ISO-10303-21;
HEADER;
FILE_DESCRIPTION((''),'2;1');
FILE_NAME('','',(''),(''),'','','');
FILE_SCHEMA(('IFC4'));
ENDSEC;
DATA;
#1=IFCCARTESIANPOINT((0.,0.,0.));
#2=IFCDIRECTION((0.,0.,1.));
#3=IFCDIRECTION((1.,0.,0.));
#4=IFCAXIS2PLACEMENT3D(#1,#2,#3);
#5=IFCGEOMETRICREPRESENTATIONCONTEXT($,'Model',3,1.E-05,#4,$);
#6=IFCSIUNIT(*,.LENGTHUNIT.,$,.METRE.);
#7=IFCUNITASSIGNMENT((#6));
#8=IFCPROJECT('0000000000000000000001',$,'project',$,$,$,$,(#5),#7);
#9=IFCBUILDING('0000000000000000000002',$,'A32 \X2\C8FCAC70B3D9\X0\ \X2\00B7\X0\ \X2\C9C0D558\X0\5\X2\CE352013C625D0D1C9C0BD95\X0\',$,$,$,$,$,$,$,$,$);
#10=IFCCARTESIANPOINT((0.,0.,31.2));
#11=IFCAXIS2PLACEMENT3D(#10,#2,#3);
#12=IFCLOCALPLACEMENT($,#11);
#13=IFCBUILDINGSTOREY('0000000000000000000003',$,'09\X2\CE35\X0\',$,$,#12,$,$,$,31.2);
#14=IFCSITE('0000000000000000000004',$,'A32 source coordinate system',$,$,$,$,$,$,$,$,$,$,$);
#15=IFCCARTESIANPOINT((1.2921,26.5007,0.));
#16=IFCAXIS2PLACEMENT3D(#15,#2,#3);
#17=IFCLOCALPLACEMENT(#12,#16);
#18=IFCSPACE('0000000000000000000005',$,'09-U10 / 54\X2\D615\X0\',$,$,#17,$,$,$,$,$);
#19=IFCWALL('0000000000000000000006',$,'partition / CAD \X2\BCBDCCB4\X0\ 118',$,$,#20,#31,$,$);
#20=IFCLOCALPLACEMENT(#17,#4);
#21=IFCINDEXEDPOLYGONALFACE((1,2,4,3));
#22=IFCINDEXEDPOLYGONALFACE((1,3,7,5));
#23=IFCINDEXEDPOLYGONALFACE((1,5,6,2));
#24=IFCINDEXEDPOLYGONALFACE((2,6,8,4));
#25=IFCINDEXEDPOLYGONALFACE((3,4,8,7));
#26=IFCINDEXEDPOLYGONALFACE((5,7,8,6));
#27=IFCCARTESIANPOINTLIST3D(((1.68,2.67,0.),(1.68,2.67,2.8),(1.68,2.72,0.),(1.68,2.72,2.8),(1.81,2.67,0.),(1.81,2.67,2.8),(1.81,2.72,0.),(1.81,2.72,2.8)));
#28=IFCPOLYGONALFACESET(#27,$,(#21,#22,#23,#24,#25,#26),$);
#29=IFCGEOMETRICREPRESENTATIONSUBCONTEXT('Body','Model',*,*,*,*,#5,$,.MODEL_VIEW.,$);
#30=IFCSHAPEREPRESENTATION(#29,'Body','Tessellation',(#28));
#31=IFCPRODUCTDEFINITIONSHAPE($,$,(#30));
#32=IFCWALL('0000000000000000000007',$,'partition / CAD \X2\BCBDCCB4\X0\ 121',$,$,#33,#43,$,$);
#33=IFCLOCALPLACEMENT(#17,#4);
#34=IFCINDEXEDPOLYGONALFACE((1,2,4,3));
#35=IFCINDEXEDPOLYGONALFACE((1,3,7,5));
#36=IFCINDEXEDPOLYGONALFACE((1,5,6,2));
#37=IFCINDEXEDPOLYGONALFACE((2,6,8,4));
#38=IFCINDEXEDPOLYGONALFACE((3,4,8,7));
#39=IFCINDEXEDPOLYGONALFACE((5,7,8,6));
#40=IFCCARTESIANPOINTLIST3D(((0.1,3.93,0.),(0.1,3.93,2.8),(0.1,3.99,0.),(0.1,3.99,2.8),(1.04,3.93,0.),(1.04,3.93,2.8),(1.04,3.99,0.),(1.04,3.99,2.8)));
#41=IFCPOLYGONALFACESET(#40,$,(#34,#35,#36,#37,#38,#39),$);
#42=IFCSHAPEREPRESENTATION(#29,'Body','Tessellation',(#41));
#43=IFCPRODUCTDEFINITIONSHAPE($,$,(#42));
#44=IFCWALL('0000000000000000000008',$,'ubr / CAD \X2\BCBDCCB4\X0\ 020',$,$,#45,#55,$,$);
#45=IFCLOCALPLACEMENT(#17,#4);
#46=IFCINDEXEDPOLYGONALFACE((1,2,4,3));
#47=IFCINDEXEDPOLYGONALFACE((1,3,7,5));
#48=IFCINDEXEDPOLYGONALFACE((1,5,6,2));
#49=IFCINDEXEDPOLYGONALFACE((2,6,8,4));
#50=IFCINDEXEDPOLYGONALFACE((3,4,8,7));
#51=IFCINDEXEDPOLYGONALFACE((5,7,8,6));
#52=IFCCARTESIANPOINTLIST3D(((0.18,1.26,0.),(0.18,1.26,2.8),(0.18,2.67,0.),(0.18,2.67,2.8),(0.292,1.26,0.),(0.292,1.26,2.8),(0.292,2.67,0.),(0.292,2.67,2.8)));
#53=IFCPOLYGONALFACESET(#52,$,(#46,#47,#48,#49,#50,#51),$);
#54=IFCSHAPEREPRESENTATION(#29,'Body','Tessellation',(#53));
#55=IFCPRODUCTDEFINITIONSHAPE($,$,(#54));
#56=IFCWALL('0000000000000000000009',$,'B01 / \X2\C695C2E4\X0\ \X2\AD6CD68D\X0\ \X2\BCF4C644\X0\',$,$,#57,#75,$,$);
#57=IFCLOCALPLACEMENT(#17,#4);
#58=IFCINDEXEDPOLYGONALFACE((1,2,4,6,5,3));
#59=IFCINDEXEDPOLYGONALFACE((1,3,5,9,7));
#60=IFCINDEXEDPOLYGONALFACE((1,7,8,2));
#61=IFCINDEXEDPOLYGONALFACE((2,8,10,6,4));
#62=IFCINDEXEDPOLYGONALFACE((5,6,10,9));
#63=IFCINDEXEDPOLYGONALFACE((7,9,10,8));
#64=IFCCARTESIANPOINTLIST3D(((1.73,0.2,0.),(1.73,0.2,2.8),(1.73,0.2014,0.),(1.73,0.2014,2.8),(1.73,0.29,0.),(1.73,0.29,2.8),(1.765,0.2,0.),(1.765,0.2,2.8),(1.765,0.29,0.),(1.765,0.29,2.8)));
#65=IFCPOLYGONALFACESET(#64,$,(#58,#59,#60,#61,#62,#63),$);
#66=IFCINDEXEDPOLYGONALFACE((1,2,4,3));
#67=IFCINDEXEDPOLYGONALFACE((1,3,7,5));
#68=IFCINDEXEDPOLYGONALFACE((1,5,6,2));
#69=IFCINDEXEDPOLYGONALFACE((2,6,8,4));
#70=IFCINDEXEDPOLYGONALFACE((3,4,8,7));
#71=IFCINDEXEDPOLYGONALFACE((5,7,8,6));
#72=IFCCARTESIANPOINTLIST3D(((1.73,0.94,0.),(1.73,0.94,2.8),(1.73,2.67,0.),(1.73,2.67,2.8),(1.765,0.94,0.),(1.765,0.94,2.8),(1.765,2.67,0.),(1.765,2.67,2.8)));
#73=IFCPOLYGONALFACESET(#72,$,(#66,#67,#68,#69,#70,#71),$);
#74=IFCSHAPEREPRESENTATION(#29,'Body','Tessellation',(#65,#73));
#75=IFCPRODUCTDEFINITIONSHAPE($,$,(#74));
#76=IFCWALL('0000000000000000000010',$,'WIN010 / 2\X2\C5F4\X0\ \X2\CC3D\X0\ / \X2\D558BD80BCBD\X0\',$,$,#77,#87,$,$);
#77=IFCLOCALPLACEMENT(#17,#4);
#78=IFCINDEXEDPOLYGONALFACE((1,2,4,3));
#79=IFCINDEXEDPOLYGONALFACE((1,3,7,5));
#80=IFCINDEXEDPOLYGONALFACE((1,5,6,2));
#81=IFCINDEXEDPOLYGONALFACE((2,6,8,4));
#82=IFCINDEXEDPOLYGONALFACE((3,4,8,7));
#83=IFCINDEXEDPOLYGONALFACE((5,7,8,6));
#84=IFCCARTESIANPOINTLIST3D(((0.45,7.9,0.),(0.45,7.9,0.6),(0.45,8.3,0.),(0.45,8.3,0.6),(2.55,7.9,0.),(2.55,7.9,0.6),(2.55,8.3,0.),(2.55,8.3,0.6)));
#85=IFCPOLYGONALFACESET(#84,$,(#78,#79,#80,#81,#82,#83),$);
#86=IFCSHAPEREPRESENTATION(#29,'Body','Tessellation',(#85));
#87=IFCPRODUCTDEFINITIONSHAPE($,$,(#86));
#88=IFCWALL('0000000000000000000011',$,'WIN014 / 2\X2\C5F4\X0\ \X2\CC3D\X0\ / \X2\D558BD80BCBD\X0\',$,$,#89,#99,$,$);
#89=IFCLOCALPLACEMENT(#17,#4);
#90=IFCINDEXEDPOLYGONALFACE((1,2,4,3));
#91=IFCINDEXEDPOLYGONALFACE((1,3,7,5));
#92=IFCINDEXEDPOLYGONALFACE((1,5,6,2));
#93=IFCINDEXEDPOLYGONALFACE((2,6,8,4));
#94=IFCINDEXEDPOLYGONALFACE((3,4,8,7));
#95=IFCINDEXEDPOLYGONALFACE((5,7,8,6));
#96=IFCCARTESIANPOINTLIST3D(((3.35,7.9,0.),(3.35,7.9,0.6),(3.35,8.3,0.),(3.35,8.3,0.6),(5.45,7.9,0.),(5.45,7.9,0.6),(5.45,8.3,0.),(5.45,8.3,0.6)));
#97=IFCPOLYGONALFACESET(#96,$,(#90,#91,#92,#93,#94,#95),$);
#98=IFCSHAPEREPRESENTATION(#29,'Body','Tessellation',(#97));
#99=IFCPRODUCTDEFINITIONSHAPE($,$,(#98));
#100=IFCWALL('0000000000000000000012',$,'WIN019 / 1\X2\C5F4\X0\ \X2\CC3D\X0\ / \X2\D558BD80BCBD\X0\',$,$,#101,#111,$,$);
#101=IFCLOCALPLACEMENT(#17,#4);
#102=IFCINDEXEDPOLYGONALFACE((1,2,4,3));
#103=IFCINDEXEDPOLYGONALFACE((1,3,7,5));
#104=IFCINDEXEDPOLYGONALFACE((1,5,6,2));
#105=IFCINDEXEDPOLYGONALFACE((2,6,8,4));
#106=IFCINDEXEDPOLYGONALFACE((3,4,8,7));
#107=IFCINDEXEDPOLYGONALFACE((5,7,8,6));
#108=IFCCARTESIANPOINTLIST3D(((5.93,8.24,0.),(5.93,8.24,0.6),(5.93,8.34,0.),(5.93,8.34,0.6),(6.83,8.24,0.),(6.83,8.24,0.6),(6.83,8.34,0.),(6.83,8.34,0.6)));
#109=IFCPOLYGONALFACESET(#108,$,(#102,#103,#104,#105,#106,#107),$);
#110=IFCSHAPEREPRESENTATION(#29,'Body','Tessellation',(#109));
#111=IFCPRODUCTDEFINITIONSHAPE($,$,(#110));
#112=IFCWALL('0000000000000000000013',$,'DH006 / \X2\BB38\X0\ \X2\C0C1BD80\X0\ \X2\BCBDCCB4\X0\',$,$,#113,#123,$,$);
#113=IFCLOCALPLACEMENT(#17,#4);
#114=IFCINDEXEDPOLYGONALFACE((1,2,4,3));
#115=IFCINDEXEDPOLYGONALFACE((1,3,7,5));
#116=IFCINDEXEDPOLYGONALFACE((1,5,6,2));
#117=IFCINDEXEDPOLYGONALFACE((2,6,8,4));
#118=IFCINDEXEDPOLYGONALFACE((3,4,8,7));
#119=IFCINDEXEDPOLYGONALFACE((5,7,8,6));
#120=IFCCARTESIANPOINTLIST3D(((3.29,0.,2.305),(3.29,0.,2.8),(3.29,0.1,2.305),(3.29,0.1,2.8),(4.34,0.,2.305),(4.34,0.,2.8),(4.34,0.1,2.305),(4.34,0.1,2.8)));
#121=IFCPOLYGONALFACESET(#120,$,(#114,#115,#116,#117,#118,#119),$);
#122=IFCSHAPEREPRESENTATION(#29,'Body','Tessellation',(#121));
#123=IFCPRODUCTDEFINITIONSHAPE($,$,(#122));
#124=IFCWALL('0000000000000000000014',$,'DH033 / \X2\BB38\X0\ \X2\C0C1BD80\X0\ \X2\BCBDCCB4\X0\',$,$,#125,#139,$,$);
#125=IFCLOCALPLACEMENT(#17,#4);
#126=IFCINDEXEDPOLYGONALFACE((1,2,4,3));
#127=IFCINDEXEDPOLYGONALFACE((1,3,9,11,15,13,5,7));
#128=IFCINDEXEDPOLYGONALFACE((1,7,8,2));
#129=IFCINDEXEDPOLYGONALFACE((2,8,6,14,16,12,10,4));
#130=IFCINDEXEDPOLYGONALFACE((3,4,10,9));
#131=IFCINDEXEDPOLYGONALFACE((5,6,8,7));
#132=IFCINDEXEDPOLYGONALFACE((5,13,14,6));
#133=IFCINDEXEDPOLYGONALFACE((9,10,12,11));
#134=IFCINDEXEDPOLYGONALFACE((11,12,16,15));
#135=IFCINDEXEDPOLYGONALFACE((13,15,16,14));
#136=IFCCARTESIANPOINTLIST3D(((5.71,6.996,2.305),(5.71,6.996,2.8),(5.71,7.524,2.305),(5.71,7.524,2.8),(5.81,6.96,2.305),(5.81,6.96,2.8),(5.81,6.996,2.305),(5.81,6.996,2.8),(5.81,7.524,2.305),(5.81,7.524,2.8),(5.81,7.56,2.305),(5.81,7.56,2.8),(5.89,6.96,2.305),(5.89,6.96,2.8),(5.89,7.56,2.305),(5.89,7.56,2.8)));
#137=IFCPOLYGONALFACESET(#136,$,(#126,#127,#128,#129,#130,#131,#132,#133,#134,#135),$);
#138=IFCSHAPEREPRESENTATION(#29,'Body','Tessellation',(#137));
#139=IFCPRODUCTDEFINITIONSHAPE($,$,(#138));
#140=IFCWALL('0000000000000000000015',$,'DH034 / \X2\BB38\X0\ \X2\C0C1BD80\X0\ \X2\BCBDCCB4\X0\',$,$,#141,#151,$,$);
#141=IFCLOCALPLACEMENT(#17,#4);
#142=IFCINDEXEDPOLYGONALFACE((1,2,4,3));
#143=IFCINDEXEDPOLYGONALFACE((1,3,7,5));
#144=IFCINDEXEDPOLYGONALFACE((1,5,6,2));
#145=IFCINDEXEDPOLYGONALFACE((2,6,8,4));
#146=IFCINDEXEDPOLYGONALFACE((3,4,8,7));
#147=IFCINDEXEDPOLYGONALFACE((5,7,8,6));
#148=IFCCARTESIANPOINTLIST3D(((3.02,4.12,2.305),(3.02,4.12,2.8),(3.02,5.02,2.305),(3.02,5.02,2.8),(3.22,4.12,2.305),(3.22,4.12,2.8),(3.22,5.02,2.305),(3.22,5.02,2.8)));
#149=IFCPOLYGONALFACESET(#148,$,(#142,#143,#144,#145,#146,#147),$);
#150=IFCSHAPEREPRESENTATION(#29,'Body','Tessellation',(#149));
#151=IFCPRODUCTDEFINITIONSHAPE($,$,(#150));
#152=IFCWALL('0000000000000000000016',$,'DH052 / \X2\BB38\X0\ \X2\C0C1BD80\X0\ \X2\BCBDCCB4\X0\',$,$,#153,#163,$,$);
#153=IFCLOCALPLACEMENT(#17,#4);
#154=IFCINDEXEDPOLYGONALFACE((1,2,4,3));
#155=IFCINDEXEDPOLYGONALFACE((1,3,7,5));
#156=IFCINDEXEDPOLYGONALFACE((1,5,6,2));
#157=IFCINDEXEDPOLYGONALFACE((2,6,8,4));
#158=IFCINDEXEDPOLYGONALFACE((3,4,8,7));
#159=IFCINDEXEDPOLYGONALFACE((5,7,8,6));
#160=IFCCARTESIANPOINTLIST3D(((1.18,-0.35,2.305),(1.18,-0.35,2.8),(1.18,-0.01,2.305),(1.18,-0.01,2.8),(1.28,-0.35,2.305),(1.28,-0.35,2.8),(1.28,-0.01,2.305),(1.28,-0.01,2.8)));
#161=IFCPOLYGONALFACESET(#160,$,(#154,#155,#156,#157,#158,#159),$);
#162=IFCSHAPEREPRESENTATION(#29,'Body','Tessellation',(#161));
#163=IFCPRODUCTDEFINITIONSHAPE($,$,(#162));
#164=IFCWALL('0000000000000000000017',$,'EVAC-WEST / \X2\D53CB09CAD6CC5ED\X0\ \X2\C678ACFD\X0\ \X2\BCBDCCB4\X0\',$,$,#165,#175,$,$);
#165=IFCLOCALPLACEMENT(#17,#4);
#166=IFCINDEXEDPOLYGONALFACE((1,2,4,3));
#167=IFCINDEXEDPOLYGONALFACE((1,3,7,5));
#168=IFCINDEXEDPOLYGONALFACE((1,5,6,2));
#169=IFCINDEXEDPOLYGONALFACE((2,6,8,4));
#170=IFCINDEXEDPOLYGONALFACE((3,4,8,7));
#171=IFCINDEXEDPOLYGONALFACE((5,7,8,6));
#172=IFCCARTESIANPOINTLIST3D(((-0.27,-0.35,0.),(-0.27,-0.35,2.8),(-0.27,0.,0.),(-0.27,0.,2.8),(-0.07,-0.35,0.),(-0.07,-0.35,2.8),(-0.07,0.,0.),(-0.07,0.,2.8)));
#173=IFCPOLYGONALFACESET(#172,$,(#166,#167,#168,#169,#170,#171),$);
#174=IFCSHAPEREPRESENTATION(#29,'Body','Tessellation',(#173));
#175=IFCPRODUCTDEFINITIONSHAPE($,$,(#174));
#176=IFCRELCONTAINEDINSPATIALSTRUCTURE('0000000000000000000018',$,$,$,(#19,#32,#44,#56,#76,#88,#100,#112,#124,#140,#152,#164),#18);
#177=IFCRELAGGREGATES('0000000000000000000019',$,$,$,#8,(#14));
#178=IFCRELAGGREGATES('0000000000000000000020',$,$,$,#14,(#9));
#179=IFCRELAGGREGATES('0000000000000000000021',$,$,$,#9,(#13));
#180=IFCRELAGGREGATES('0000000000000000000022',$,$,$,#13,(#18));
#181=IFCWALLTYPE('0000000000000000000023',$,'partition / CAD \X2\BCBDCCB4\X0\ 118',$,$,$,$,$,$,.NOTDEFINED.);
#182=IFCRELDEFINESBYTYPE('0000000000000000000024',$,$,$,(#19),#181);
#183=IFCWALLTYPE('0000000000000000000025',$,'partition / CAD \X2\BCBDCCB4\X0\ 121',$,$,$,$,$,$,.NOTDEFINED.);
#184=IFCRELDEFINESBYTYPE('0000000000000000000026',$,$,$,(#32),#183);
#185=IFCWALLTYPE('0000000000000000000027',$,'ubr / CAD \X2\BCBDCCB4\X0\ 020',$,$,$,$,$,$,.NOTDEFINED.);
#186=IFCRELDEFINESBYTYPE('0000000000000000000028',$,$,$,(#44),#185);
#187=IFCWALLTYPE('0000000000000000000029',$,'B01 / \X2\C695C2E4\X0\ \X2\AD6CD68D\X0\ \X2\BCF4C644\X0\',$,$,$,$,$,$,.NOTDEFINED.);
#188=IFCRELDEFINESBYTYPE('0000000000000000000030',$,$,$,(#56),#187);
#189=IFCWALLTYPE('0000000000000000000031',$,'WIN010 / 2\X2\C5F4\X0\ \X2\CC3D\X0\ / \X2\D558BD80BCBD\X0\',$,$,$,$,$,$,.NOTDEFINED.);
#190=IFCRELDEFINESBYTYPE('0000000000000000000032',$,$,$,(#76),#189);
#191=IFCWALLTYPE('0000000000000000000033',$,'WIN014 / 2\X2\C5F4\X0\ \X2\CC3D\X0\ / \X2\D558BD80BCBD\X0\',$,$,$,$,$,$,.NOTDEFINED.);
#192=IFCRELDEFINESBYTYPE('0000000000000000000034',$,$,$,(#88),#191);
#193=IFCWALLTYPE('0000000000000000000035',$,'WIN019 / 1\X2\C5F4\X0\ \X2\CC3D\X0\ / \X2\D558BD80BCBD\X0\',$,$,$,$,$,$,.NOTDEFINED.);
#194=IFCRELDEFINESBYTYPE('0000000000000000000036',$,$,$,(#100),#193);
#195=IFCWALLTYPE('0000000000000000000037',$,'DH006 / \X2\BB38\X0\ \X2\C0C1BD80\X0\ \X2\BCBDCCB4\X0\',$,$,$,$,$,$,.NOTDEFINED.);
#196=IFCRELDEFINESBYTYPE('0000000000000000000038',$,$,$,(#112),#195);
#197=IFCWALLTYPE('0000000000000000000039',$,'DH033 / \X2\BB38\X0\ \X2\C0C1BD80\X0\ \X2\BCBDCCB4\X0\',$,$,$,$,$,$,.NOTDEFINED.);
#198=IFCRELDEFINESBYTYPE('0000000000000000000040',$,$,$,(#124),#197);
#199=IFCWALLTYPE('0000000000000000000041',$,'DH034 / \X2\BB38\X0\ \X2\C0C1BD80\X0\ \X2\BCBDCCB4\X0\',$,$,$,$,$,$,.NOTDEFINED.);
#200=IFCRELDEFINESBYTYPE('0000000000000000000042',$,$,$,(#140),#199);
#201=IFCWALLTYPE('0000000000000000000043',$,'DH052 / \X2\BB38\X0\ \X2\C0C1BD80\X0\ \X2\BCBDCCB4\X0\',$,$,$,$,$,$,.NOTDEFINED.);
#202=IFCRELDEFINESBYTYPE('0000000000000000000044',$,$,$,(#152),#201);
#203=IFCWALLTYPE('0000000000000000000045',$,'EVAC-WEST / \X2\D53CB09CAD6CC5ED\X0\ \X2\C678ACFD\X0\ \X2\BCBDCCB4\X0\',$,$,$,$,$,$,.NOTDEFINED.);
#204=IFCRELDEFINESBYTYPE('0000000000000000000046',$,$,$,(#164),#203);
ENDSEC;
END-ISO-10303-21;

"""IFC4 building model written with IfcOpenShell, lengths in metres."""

from ifc_helpers import new_model, si_unit, frame, origin, origin_with_axes, place, context, subcontext, project, spatial, polyline, outline, extrude, source, transform, mapped, type_object, type_shapes, element, save


model = new_model("IFC4")

# Units and contexts
model_context = context("Model", 3, precision=1e-05, world=origin_with_axes())
body_context = subcontext(model_context, "Body", "Model", "MODEL_VIEW")
ifc_project = project(units=[si_unit("LENGTHUNIT", "METRE")], contexts=[model_context])

# Site, building, storey, space
site = spatial("IfcSite", under=ifc_project, Name="A32 source coordinate system")
building = spatial("IfcBuilding", under=site, Name="A32 주거동 · 지하5층–옥탑지붕")
storey_placement = place(None, frame((0.0, 0.0, 31.2), z_axis=(0.0, 0.0, 1.0), x_axis=(1.0, 0.0, 0.0)))
storey = spatial("IfcBuildingStorey", under=building, at=storey_placement, Name="09층", Elevation=31.2)
space_placement = place(storey_placement, frame((1.2921, 26.5007, 0.0), z_axis=(0.0, 0.0, 1.0), x_axis=(1.0, 0.0, 0.0)))
space = spatial("IfcSpace", under=storey, at=space_placement, Name="09-U10 / 54형")

# Walls
wall_type_1 = type_object("IfcWallType", Name="partition / CAD 벽체 118", PredefinedType="NOTDEFINED")
shared_shape_1 = source(origin(), body_context, "Body", "SweptSolid", [
    extrude(outline(polyline([(1.81, 2.67), (1.68, 2.67), (1.68, 2.72), (1.81, 2.72), (1.81, 2.67)])), origin(), (0.0, 0.0, 1.0), 2.8),
])
type_shapes(wall_type_1, [shared_shape_1])
wall_1_placement = place(space_placement, origin_with_axes())
element("IfcWall", 1, at=wall_1_placement, inside=space, type_object=wall_type_1, Name="partition / CAD 벽체 118", context=body_context, shape_type="MappedRepresentation", body=[
    mapped(shared_shape_1, transform((0.0, 0.0, 0.0), scale=1.0)),
])
wall_type_2 = type_object("IfcWallType", Name="partition / CAD 벽체 121", PredefinedType="NOTDEFINED")
shared_shape_2 = source(origin(), body_context, "Body", "SweptSolid", [
    extrude(outline(polyline([(0.1, 3.99), (1.04, 3.99), (1.04, 3.93), (0.1, 3.93), (0.1, 3.99)])), origin(), (0.0, 0.0, 1.0), 2.8),
])
type_shapes(wall_type_2, [shared_shape_2])
wall_2_placement = place(space_placement, origin_with_axes())
element("IfcWall", 2, at=wall_2_placement, inside=space, type_object=wall_type_2, Name="partition / CAD 벽체 121", context=body_context, shape_type="MappedRepresentation", body=[
    mapped(shared_shape_2, transform((0.0, 0.0, 0.0), scale=1.0)),
])
wall_type_3 = type_object("IfcWallType", Name="ubr / CAD 벽체 020", PredefinedType="NOTDEFINED")
shared_shape_3 = source(origin(), body_context, "Body", "SweptSolid", [
    extrude(outline(polyline([(0.18, 1.26), (0.18, 2.67), (0.292, 2.67), (0.292, 1.26), (0.18, 1.26)])), origin(), (0.0, 0.0, 1.0), 2.8),
])
type_shapes(wall_type_3, [shared_shape_3])
wall_3_placement = place(space_placement, origin_with_axes())
element("IfcWall", 3, at=wall_3_placement, inside=space, type_object=wall_type_3, Name="ubr / CAD 벽체 020", context=body_context, shape_type="MappedRepresentation", body=[
    mapped(shared_shape_3, transform((0.0, 0.0, 0.0), scale=1.0)),
])
wall_type_4 = type_object("IfcWallType", Name="B01 / 욕실 구획 보완", PredefinedType="NOTDEFINED")
shared_shape_4 = source(origin(), body_context, "Body", "SweptSolid", [
    extrude(outline(polyline([(1.765, 0.2), (1.73, 0.2), (1.73, 0.2014), (1.73, 0.29), (1.765, 0.29), (1.765, 0.2)])), origin(), (0.0, 0.0, 1.0), 2.8),
    extrude(outline(polyline([(1.765, 2.67), (1.765, 0.94), (1.73, 0.94), (1.73, 2.67), (1.765, 2.67)])), origin(), (0.0, 0.0, 1.0), 2.8),
])
type_shapes(wall_type_4, [shared_shape_4])
wall_4_placement = place(space_placement, origin_with_axes())
element("IfcWall", 4, at=wall_4_placement, inside=space, type_object=wall_type_4, Name="B01 / 욕실 구획 보완", context=body_context, shape_type="MappedRepresentation", body=[
    mapped(shared_shape_4, transform((0.0, 0.0, 0.0), scale=1.0)),
])
wall_type_5 = type_object("IfcWallType", Name="WIN010 / 2열 창 / 하부벽", PredefinedType="NOTDEFINED")
shared_shape_5 = source(origin(), body_context, "Body", "SweptSolid", [
    extrude(outline(polyline([(2.55, 8.3), (2.55, 7.9), (0.45, 7.9), (0.45, 8.3), (2.55, 8.3)])), origin(), (0.0, 0.0, 1.0), 0.6),
])
type_shapes(wall_type_5, [shared_shape_5])
wall_5_placement = place(space_placement, origin_with_axes())
element("IfcWall", 5, at=wall_5_placement, inside=space, type_object=wall_type_5, Name="WIN010 / 2열 창 / 하부벽", context=body_context, shape_type="MappedRepresentation", body=[
    mapped(shared_shape_5, transform((0.0, 0.0, 0.0), scale=1.0)),
])
wall_type_6 = type_object("IfcWallType", Name="WIN014 / 2열 창 / 하부벽", PredefinedType="NOTDEFINED")
shared_shape_6 = source(origin(), body_context, "Body", "SweptSolid", [
    extrude(outline(polyline([(5.45, 8.3), (5.45, 7.9), (3.35, 7.9), (3.35, 8.3), (5.45, 8.3)])), origin(), (0.0, 0.0, 1.0), 0.6),
])
type_shapes(wall_type_6, [shared_shape_6])
wall_6_placement = place(space_placement, origin_with_axes())
element("IfcWall", 6, at=wall_6_placement, inside=space, type_object=wall_type_6, Name="WIN014 / 2열 창 / 하부벽", context=body_context, shape_type="MappedRepresentation", body=[
    mapped(shared_shape_6, transform((0.0, 0.0, 0.0), scale=1.0)),
])
wall_type_7 = type_object("IfcWallType", Name="WIN019 / 1열 창 / 하부벽", PredefinedType="NOTDEFINED")
shared_shape_7 = source(origin(), body_context, "Body", "SweptSolid", [
    extrude(outline(polyline([(6.83, 8.34), (6.83, 8.24), (5.93, 8.24), (5.93, 8.34), (6.83, 8.34)])), origin(), (0.0, 0.0, 1.0), 0.6),
])
type_shapes(wall_type_7, [shared_shape_7])
wall_7_placement = place(space_placement, origin_with_axes())
element("IfcWall", 7, at=wall_7_placement, inside=space, type_object=wall_type_7, Name="WIN019 / 1열 창 / 하부벽", context=body_context, shape_type="MappedRepresentation", body=[
    mapped(shared_shape_7, transform((0.0, 0.0, 0.0), scale=1.0)),
])
wall_type_8 = type_object("IfcWallType", Name="DH006 / 문 상부 벽체", PredefinedType="NOTDEFINED")
shared_shape_8 = source(origin(), body_context, "Body", "SweptSolid", [
    extrude(outline(polyline([(4.34, 0.0), (3.29, 0.0), (3.29, 0.1), (4.34, 0.1), (4.34, 0.0)])), frame((0.0, 0.0, 2.305)), (0.0, 0.0, 1.0), 0.495),
])
type_shapes(wall_type_8, [shared_shape_8])
wall_8_placement = place(space_placement, origin_with_axes())
element("IfcWall", 8, at=wall_8_placement, inside=space, type_object=wall_type_8, Name="DH006 / 문 상부 벽체", context=body_context, shape_type="MappedRepresentation", body=[
    mapped(shared_shape_8, transform((0.0, 0.0, 0.0), scale=1.0)),
])
wall_type_9 = type_object("IfcWallType", Name="DH033 / 문 상부 벽체", PredefinedType="NOTDEFINED")
shared_shape_9 = source(origin(), body_context, "Body", "SweptSolid", [
    extrude(outline(polyline([(5.81, 6.996), (5.71, 6.996), (5.71, 7.524), (5.81, 7.524), (5.81, 7.56), (5.89, 7.56), (5.89, 6.96), (5.81, 6.96), (5.81, 6.996)])), frame((0.0, 0.0, 2.305)), (0.0, 0.0, 1.0), 0.495),
])
type_shapes(wall_type_9, [shared_shape_9])
wall_9_placement = place(space_placement, origin_with_axes())
element("IfcWall", 9, at=wall_9_placement, inside=space, type_object=wall_type_9, Name="DH033 / 문 상부 벽체", context=body_context, shape_type="MappedRepresentation", body=[
    mapped(shared_shape_9, transform((0.0, 0.0, 0.0), scale=1.0)),
])
wall_type_10 = type_object("IfcWallType", Name="DH034 / 문 상부 벽체", PredefinedType="NOTDEFINED")
shared_shape_10 = source(origin(), body_context, "Body", "SweptSolid", [
    extrude(outline(polyline([(3.22, 4.12), (3.02, 4.12), (3.02, 5.02), (3.22, 5.02), (3.22, 4.12)])), frame((0.0, 0.0, 2.305)), (0.0, 0.0, 1.0), 0.495),
])
type_shapes(wall_type_10, [shared_shape_10])
wall_10_placement = place(space_placement, origin_with_axes())
element("IfcWall", 10, at=wall_10_placement, inside=space, type_object=wall_type_10, Name="DH034 / 문 상부 벽체", context=body_context, shape_type="MappedRepresentation", body=[
    mapped(shared_shape_10, transform((0.0, 0.0, 0.0), scale=1.0)),
])
wall_type_11 = type_object("IfcWallType", Name="DH052 / 문 상부 벽체", PredefinedType="NOTDEFINED")
shared_shape_11 = source(origin(), body_context, "Body", "SweptSolid", [
    extrude(outline(polyline([(1.28, -0.35), (1.18, -0.35), (1.18, -0.01), (1.28, -0.01), (1.28, -0.35)])), frame((0.0, 0.0, 2.305)), (0.0, 0.0, 1.0), 0.495),
])
type_shapes(wall_type_11, [shared_shape_11])
wall_11_placement = place(space_placement, origin_with_axes())
element("IfcWall", 11, at=wall_11_placement, inside=space, type_object=wall_type_11, Name="DH052 / 문 상부 벽체", context=body_context, shape_type="MappedRepresentation", body=[
    mapped(shared_shape_11, transform((0.0, 0.0, 0.0), scale=1.0)),
])
wall_type_12 = type_object("IfcWallType", Name="EVAC-WEST / 피난구역 외곽 벽체", PredefinedType="NOTDEFINED")
shared_shape_12 = source(origin(), body_context, "Body", "SweptSolid", [
    extrude(outline(polyline([(-0.07, 0.0), (-0.07, -0.35), (-0.27, -0.35), (-0.27, 0.0), (-0.07, 0.0)])), origin(), (0.0, 0.0, 1.0), 2.8),
])
type_shapes(wall_type_12, [shared_shape_12])
wall_12_placement = place(space_placement, origin_with_axes())
element("IfcWall", 12, at=wall_12_placement, inside=space, type_object=wall_type_12, Name="EVAC-WEST / 피난구역 외곽 벽체", context=body_context, shape_type="MappedRepresentation", body=[
    mapped(shared_shape_12, transform((0.0, 0.0, 0.0), scale=1.0)),
])

save(model, "model.ifc")
